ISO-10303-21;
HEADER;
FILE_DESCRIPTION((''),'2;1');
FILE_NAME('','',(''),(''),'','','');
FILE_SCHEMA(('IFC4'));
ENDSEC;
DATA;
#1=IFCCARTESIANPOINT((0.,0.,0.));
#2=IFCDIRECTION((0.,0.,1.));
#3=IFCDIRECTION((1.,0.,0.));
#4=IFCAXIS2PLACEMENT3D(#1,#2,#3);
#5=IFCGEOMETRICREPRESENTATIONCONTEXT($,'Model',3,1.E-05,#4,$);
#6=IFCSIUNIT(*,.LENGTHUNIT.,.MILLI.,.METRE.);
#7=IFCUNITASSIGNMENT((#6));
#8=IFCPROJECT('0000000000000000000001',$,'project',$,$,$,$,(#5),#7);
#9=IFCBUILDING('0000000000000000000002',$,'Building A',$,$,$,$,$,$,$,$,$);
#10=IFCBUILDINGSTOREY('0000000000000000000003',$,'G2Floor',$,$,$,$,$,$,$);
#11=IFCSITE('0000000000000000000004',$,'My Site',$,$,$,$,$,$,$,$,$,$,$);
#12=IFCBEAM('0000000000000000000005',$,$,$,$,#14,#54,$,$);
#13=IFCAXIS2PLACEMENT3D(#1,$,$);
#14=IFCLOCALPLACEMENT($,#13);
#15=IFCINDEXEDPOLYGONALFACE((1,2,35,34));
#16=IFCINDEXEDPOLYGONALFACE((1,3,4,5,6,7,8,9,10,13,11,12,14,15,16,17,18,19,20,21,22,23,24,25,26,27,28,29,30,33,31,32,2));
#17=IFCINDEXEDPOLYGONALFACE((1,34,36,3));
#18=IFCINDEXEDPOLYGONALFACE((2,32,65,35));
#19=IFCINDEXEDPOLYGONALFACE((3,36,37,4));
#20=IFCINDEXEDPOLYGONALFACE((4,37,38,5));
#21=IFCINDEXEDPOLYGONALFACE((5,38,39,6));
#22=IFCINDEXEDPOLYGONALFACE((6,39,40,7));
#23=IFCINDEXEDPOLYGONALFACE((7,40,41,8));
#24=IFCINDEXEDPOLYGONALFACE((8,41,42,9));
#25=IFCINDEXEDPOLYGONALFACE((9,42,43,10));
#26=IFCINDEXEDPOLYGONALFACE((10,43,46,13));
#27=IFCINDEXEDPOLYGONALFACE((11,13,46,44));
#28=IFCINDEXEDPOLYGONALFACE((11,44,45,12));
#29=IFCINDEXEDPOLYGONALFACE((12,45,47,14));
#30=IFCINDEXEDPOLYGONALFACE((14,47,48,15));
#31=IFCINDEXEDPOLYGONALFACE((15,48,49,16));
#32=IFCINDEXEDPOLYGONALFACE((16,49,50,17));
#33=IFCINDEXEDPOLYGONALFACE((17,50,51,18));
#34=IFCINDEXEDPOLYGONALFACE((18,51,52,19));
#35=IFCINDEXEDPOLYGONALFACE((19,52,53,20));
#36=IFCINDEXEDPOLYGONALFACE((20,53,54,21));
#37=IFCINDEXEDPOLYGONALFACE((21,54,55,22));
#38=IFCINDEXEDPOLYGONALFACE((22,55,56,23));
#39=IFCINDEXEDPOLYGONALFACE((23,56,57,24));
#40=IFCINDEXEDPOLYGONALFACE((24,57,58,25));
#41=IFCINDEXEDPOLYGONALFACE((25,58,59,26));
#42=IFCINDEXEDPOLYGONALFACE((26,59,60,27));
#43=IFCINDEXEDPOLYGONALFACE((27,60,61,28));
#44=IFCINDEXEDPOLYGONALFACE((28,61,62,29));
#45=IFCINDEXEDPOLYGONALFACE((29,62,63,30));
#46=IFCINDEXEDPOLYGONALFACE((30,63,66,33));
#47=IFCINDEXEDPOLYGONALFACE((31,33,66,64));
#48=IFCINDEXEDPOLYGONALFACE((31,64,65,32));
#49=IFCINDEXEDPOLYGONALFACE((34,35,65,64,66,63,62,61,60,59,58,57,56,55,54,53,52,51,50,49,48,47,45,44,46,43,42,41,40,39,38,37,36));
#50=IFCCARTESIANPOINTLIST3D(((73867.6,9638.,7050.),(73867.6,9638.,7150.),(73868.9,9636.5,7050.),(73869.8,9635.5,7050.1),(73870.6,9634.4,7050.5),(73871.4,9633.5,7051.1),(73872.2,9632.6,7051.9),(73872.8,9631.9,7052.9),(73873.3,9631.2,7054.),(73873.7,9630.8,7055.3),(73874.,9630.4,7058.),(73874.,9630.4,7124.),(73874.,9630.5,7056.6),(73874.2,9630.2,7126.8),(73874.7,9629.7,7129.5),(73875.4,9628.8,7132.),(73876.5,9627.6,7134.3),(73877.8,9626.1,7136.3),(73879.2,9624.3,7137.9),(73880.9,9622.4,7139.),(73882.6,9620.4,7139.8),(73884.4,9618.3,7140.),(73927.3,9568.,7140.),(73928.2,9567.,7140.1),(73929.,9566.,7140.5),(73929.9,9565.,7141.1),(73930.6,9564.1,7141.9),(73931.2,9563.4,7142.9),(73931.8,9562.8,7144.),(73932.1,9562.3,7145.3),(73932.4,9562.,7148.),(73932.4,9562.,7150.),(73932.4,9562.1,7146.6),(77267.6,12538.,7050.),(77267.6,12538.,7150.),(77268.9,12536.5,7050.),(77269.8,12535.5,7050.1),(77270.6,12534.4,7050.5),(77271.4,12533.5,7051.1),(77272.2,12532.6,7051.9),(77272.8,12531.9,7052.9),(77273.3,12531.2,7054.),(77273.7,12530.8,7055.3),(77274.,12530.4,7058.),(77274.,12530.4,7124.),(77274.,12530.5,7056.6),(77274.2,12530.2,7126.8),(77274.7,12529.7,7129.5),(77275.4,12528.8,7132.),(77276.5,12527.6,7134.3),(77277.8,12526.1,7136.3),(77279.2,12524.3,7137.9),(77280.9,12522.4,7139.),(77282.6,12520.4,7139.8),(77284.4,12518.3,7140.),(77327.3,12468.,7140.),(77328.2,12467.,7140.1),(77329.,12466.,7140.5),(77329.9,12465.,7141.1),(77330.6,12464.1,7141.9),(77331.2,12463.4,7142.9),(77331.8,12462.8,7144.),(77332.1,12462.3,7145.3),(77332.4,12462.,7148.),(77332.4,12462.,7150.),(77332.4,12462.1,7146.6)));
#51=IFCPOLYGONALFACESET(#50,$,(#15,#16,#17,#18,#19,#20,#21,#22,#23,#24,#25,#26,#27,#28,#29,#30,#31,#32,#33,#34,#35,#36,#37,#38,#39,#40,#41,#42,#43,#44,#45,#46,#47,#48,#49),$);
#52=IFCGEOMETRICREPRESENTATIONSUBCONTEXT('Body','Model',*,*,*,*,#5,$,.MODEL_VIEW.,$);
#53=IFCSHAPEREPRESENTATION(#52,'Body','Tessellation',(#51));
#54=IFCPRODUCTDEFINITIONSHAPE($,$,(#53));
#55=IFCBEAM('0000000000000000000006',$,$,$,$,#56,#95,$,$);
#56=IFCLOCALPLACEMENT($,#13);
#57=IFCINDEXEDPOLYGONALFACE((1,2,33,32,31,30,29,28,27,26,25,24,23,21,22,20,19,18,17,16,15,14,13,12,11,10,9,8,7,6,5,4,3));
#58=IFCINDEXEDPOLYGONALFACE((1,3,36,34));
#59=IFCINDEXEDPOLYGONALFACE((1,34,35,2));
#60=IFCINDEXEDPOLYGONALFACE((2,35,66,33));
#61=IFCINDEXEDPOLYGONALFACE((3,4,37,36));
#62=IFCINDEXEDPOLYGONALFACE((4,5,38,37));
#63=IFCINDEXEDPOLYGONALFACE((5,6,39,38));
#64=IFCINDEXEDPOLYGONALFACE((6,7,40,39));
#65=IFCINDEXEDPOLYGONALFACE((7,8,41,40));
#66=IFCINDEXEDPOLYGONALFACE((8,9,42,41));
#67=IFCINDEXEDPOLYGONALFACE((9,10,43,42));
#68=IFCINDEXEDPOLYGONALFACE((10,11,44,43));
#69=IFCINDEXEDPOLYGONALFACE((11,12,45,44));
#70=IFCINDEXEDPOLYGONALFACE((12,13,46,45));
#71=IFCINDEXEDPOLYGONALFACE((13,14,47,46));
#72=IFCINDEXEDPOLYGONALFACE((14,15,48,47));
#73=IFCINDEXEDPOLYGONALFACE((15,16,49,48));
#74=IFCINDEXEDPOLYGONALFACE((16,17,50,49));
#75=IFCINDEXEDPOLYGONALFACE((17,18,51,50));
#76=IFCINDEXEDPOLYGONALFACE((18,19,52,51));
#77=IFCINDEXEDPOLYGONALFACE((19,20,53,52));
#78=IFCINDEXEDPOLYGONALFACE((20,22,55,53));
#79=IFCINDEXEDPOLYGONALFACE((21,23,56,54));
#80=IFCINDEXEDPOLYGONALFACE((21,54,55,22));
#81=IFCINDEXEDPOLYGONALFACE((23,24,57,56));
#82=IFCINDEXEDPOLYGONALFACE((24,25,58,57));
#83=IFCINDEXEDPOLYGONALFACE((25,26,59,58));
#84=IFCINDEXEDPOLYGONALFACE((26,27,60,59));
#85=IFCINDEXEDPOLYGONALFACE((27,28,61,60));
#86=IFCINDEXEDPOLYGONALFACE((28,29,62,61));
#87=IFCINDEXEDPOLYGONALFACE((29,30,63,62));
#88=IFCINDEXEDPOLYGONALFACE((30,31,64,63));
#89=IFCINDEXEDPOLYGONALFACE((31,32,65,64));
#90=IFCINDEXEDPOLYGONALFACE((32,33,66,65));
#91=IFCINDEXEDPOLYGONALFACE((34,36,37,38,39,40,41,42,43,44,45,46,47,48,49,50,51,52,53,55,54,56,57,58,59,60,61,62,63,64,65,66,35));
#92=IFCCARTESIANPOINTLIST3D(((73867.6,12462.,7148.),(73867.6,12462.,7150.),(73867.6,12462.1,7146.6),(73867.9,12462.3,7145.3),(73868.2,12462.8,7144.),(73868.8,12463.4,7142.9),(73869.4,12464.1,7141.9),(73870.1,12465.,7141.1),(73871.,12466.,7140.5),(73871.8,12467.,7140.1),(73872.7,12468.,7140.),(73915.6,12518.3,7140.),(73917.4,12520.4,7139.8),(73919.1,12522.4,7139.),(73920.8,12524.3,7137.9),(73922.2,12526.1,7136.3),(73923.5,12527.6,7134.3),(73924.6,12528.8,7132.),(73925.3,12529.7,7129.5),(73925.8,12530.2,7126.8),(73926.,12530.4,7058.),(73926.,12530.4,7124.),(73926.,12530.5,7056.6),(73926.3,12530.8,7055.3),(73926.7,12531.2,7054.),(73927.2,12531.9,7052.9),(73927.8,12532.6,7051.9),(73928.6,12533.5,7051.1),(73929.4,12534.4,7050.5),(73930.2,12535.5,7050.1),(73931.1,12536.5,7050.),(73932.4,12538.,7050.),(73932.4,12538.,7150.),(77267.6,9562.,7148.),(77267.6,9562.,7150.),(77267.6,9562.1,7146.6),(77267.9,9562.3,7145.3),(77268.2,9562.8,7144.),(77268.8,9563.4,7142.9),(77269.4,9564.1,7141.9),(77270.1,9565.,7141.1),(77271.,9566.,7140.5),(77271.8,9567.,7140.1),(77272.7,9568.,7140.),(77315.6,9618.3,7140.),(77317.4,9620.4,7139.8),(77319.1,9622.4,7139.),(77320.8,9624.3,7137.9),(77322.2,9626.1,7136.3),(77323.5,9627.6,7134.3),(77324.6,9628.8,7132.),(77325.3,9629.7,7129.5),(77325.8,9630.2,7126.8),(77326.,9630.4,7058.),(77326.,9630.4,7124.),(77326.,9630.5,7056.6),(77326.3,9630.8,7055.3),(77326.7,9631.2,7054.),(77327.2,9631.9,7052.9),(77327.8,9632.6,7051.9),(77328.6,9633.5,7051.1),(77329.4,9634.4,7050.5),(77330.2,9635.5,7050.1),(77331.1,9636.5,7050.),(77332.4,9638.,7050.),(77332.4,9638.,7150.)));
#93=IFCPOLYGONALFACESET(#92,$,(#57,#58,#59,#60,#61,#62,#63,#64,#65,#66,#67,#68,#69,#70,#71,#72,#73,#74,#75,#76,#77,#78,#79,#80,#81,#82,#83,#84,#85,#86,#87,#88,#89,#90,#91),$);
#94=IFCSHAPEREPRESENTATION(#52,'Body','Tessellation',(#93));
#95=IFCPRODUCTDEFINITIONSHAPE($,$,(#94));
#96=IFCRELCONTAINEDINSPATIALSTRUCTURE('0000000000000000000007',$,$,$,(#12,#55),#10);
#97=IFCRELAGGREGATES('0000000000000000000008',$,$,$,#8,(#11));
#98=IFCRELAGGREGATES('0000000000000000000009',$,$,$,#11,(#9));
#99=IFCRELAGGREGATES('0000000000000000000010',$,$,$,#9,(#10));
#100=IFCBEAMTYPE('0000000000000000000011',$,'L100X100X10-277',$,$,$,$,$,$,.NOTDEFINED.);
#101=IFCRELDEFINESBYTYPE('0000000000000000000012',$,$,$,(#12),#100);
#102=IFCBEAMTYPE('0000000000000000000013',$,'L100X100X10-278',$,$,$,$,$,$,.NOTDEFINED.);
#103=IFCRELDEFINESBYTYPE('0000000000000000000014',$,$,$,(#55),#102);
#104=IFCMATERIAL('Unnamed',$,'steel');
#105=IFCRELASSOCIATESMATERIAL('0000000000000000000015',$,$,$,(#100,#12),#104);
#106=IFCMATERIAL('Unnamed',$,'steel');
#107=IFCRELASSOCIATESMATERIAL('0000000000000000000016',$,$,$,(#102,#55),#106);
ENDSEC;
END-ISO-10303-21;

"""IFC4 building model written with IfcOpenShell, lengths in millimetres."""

from ifc_helpers import new_model, si_unit, frame, origin_with_axes, place, context, subcontext, project, spatial, polyline, outline, extrude, material, material_profile, profile_set, profile_usage, type_object, element, save


model = new_model("IFC4")

# Units and contexts
model_context = context("Model", 3, precision=1e-05, world=origin_with_axes())
body_context = subcontext(model_context, "Body", "Model", "MODEL_VIEW")
ifc_project = project(units=[si_unit("LENGTHUNIT", "METRE", prefix="MILLI")], contexts=[model_context])

# Site, building, storey
site = spatial("IfcSite", under=ifc_project, Name="My Site")
building = spatial("IfcBuilding", under=site, Name="Building A")
storey = spatial("IfcBuildingStorey", under=building, Name="G2Floor")

# Beams
ifc_material_1 = material(Name="Unnamed", Category="steel")
ifc_material_profile_1 = material_profile(ifc_material_1, outline(polyline([(-50.0, -50.0), (50.0, -50.0), (50.0, -50.0), (50.0, -48.0), (50.0, -48.0), (49.9, -46.6), (49.9, -46.6), (49.5, -45.3), (49.5, -45.3), (48.9, -44.0), (48.9, -44.0), (48.1, -42.9), (48.1, -42.9), (47.1, -41.9), (47.1, -41.9), (46.0, -41.1), (46.0, -41.1), (44.7, -40.5), (44.7, -40.5), (43.4, -40.1), (43.4, -40.1), (42.0, -40.0), (42.0, -40.0), (-24.0, -40.0), (-24.0, -40.0), (-26.8, -39.8), (-26.8, -39.8), (-29.5, -39.0), (-29.5, -39.0), (-32.0, -37.9), (-32.0, -37.9), (-34.3, -36.3), (-34.3, -36.3), (-36.3, -34.3), (-36.3, -34.3), (-37.9, -32.0), (-37.9, -32.0), (-39.0, -29.5), (-39.0, -29.5), (-39.8, -26.8), (-39.8, -26.8), (-40.0, -24.0), (-40.0, -24.0), (-40.0, 42.0), (-40.0, 42.0), (-40.1, 43.4), (-40.1, 43.4), (-40.5, 44.7), (-40.5, 44.7), (-41.1, 46.0), (-41.1, 46.0), (-41.9, 47.1), (-41.9, 47.1), (-42.9, 48.1), (-42.9, 48.1), (-44.0, 48.9), (-44.0, 48.9), (-45.3, 49.5), (-45.3, 49.5), (-46.6, 49.9), (-46.6, 49.9), (-48.0, 50.0), (-48.0, 50.0), (-50.0, 50.0), (-50.0, 50.0), (-50.0, -50.0)])))
ifc_profile_set_1 = profile_set([ifc_material_profile_1], Name="L100X100X10-277")
ifc_profile_usage_1 = profile_usage(ifc_profile_set_1)
beam_type_1 = type_object("IfcBeamType", Name="L100X100X10-277", PredefinedType="NOTDEFINED", material=ifc_profile_set_1)
beam_1_placement = place(None, frame((73900.0, 9600.0, 7100.0), z_axis=(0.760834, 0.648947, 0.0), x_axis=(0.648947, -0.760834, 0.0)))
element("IfcBeam", 1, at=beam_1_placement, inside=storey, type_object=beam_type_1, material=ifc_profile_usage_1, context=body_context, shape_type="SweptSolid", body=[
    extrude(outline(polyline([(-50.0, -50.0), (50.0, -50.0), (50.0, -50.0), (50.0, -48.0), (50.0, -48.0), (49.9, -46.6), (49.9, -46.6), (49.5, -45.3), (49.5, -45.3), (48.9, -44.0), (48.9, -44.0), (48.1, -42.9), (48.1, -42.9), (47.1, -41.9), (47.1, -41.9), (46.0, -41.1), (46.0, -41.1), (44.7, -40.5), (44.7, -40.5), (43.4, -40.1), (43.4, -40.1), (42.0, -40.0), (42.0, -40.0), (-24.0, -40.0), (-24.0, -40.0), (-26.8, -39.8), (-26.8, -39.8), (-29.5, -39.0), (-29.5, -39.0), (-32.0, -37.9), (-32.0, -37.9), (-34.3, -36.3), (-34.3, -36.3), (-36.3, -34.3), (-36.3, -34.3), (-37.9, -32.0), (-37.9, -32.0), (-39.0, -29.5), (-39.0, -29.5), (-39.8, -26.8), (-39.8, -26.8), (-40.0, -24.0), (-40.0, -24.0), (-40.0, 42.0), (-40.0, 42.0), (-40.1, 43.4), (-40.1, 43.4), (-40.5, 44.7), (-40.5, 44.7), (-41.1, 46.0), (-41.1, 46.0), (-41.9, 47.1), (-41.9, 47.1), (-42.9, 48.1), (-42.9, 48.1), (-44.0, 48.9), (-44.0, 48.9), (-45.3, 49.5), (-45.3, 49.5), (-46.6, 49.9), (-46.6, 49.9), (-48.0, 50.0), (-48.0, 50.0), (-50.0, 50.0), (-50.0, 50.0), (-50.0, -50.0)])), origin_with_axes(), (0.0, 0.0, 1.0), 4468.8),
])
ifc_material_2 = material(Name="Unnamed", Category="steel")
ifc_material_profile_2 = material_profile(ifc_material_2, outline(polyline([(-50.0, -50.0), (50.0, -50.0), (50.0, -50.0), (50.0, -48.0), (50.0, -48.0), (49.9, -46.6), (49.9, -46.6), (49.5, -45.3), (49.5, -45.3), (48.9, -44.0), (48.9, -44.0), (48.1, -42.9), (48.1, -42.9), (47.1, -41.9), (47.1, -41.9), (46.0, -41.1), (46.0, -41.1), (44.7, -40.5), (44.7, -40.5), (43.4, -40.1), (43.4, -40.1), (42.0, -40.0), (42.0, -40.0), (-24.0, -40.0), (-24.0, -40.0), (-26.8, -39.8), (-26.8, -39.8), (-29.5, -39.0), (-29.5, -39.0), (-32.0, -37.9), (-32.0, -37.9), (-34.3, -36.3), (-34.3, -36.3), (-36.3, -34.3), (-36.3, -34.3), (-37.9, -32.0), (-37.9, -32.0), (-39.0, -29.5), (-39.0, -29.5), (-39.8, -26.8), (-39.8, -26.8), (-40.0, -24.0), (-40.0, -24.0), (-40.0, 42.0), (-40.0, 42.0), (-40.1, 43.4), (-40.1, 43.4), (-40.5, 44.7), (-40.5, 44.7), (-41.1, 46.0), (-41.1, 46.0), (-41.9, 47.1), (-41.9, 47.1), (-42.9, 48.1), (-42.9, 48.1), (-44.0, 48.9), (-44.0, 48.9), (-45.3, 49.5), (-45.3, 49.5), (-46.6, 49.9), (-46.6, 49.9), (-48.0, 50.0), (-48.0, 50.0), (-50.0, 50.0), (-50.0, 50.0), (-50.0, -50.0)])))
ifc_profile_set_2 = profile_set([ifc_material_profile_2], Name="L100X100X10-278")
ifc_profile_usage_2 = profile_usage(ifc_profile_set_2)
beam_type_2 = type_object("IfcBeamType", Name="L100X100X10-278", PredefinedType="NOTDEFINED", material=ifc_profile_set_2)
beam_2_placement = place(None, frame((73900.0, 12500.0, 7100.0), z_axis=(0.760834, -0.648947, 0.0), x_axis=(-0.648947, -0.760834, 0.0)))
element("IfcBeam", 2, at=beam_2_placement, inside=storey, type_object=beam_type_2, material=ifc_profile_usage_2, context=body_context, shape_type="SweptSolid", body=[
    extrude(outline(polyline([(-50.0, -50.0), (50.0, -50.0), (50.0, -50.0), (50.0, -48.0), (50.0, -48.0), (49.9, -46.6), (49.9, -46.6), (49.5, -45.3), (49.5, -45.3), (48.9, -44.0), (48.9, -44.0), (48.1, -42.9), (48.1, -42.9), (47.1, -41.9), (47.1, -41.9), (46.0, -41.1), (46.0, -41.1), (44.7, -40.5), (44.7, -40.5), (43.4, -40.1), (43.4, -40.1), (42.0, -40.0), (42.0, -40.0), (-24.0, -40.0), (-24.0, -40.0), (-26.8, -39.8), (-26.8, -39.8), (-29.5, -39.0), (-29.5, -39.0), (-32.0, -37.9), (-32.0, -37.9), (-34.3, -36.3), (-34.3, -36.3), (-36.3, -34.3), (-36.3, -34.3), (-37.9, -32.0), (-37.9, -32.0), (-39.0, -29.5), (-39.0, -29.5), (-39.8, -26.8), (-39.8, -26.8), (-40.0, -24.0), (-40.0, -24.0), (-40.0, 42.0), (-40.0, 42.0), (-40.1, 43.4), (-40.1, 43.4), (-40.5, 44.7), (-40.5, 44.7), (-41.1, 46.0), (-41.1, 46.0), (-41.9, 47.1), (-41.9, 47.1), (-42.9, 48.1), (-42.9, 48.1), (-44.0, 48.9), (-44.0, 48.9), (-45.3, 49.5), (-45.3, 49.5), (-46.6, 49.9), (-46.6, 49.9), (-48.0, 50.0), (-48.0, 50.0), (-50.0, 50.0), (-50.0, 50.0), (-50.0, -50.0)])), origin_with_axes(), (0.0, 0.0, 1.0), 4468.8),
])

save(model, "model.ifc")
